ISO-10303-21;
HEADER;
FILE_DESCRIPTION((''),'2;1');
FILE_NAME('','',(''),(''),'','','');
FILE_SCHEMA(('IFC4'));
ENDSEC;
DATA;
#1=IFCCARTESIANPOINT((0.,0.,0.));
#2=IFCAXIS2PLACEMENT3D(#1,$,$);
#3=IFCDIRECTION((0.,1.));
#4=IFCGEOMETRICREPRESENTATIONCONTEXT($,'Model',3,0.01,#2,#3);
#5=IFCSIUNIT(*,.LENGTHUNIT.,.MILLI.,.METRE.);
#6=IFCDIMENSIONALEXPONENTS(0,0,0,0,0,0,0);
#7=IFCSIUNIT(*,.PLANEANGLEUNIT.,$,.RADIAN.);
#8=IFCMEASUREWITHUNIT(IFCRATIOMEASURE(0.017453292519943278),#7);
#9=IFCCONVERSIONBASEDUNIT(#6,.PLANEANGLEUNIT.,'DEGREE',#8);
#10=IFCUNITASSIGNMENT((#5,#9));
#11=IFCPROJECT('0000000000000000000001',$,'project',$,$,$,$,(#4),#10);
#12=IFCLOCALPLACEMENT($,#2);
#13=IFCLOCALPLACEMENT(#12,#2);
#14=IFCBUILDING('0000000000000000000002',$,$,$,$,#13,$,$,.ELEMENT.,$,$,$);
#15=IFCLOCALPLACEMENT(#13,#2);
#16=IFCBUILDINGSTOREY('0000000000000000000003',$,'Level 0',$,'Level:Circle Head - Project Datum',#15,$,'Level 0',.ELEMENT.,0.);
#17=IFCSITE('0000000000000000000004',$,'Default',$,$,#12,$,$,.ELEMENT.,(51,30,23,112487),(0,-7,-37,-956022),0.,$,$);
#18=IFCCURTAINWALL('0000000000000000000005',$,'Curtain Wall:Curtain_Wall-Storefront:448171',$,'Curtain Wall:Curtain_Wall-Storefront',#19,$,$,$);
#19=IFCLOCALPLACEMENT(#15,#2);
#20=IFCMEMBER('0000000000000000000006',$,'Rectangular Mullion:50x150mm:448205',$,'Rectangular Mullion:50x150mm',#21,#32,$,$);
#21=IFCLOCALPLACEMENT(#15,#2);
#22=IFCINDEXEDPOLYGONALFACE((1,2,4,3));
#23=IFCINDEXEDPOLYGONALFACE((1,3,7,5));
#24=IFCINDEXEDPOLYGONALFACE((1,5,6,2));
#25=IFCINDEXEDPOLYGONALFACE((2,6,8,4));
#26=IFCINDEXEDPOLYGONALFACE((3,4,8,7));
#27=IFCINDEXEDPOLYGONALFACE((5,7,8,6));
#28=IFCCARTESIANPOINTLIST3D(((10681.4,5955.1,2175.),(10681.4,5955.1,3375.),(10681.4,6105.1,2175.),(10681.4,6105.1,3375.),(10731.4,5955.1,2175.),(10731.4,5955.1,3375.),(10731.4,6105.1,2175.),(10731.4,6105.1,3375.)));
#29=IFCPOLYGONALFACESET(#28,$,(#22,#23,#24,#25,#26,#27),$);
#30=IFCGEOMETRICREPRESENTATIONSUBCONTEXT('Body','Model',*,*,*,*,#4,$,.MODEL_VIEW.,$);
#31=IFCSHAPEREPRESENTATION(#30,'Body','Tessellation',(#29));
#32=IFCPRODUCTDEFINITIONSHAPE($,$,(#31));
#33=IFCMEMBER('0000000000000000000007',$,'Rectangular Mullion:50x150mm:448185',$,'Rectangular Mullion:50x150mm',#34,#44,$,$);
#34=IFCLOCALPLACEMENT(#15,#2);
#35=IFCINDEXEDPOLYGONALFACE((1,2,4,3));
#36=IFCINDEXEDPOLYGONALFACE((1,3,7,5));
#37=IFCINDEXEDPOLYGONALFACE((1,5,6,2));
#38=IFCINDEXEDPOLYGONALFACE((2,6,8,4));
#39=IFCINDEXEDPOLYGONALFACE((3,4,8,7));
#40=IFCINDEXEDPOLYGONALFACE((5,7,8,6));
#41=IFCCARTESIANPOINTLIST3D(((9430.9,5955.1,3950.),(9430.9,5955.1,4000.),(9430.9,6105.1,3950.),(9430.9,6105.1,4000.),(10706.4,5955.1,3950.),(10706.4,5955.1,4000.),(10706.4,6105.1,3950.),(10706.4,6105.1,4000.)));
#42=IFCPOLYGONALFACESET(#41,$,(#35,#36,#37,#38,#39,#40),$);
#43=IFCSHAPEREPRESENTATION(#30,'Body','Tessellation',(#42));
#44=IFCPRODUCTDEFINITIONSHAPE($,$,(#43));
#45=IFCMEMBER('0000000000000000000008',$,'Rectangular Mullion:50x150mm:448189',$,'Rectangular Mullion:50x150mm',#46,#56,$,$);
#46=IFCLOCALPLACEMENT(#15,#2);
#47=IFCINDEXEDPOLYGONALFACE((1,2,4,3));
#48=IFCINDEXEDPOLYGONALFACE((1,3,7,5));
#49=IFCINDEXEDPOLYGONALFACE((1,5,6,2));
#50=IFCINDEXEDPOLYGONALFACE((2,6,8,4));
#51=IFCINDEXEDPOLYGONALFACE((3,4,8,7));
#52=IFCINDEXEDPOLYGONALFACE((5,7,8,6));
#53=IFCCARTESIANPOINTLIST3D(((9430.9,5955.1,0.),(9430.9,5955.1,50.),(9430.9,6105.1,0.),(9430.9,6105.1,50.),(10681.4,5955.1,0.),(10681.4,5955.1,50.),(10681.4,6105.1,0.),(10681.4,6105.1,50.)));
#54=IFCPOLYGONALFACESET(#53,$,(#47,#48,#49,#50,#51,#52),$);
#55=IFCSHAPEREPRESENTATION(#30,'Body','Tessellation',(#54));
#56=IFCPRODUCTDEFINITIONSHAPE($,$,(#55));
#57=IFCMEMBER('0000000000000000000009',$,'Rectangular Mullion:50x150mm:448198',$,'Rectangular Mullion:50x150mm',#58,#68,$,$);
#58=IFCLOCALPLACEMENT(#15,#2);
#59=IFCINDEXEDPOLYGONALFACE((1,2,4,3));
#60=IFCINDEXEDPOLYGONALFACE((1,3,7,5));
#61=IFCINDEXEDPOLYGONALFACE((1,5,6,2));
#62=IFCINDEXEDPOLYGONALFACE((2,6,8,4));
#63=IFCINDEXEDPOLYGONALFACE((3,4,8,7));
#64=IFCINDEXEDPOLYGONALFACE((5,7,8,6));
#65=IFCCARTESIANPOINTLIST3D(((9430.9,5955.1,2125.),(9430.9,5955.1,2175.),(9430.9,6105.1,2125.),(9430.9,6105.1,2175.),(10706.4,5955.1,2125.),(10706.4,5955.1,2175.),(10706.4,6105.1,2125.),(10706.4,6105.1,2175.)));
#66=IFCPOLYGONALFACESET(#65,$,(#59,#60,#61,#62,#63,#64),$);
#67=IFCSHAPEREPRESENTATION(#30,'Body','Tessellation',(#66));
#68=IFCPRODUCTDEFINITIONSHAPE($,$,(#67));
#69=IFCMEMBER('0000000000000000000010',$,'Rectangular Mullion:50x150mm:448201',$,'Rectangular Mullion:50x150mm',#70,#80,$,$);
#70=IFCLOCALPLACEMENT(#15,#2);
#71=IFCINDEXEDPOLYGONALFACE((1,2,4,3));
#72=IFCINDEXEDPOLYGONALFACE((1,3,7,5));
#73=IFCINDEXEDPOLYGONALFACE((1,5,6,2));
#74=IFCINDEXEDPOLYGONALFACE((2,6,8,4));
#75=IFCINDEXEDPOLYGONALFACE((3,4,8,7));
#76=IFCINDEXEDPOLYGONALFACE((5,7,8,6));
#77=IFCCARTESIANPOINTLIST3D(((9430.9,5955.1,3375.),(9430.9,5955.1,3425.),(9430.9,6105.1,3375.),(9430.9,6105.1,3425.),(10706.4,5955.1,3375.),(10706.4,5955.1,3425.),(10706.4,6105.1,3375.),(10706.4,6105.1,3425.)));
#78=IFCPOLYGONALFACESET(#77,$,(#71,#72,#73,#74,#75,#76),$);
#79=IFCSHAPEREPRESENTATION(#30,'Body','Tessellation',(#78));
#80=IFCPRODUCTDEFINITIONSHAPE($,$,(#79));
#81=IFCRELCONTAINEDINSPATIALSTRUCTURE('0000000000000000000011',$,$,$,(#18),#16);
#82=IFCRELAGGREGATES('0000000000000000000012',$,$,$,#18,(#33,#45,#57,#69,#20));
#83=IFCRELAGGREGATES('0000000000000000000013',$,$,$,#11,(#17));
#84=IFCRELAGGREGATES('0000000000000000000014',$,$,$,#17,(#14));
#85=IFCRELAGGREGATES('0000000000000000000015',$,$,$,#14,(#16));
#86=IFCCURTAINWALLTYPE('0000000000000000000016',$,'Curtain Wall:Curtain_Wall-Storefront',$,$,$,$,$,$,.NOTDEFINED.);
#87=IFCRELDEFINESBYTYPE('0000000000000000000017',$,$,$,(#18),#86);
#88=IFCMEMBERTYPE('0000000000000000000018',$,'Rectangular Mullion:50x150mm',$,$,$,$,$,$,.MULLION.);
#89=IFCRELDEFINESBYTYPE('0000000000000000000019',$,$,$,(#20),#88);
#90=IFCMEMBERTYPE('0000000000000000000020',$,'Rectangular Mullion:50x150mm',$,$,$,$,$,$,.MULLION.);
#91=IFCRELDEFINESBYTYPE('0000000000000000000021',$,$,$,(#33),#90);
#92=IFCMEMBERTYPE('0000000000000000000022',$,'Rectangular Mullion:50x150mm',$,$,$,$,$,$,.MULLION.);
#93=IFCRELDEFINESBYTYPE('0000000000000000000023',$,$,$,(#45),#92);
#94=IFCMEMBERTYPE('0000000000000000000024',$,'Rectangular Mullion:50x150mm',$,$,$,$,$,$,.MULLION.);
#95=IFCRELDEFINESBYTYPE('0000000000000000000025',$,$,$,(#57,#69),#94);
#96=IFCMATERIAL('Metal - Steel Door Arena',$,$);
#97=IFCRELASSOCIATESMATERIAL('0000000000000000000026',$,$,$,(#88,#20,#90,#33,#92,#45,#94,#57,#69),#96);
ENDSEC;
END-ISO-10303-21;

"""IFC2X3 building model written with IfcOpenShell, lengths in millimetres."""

from ifc_helpers import new_model, entity, si_unit, converted_unit, direction, frame, origin, origin_2d_with_axis, place, context, subcontext, project, spatial, rectangle, extrude, source, transform, mapped, material, type_object, type_shapes, element, aggregate, save


model = new_model("IFC2X3")

# Units and contexts
model_context = context("Model", 3, precision=0.01, world=origin(), true_north=direction((0.0, 1.0)))
body_context = subcontext(model_context, "Body", "Model", "MODEL_VIEW")
ifc_project = project(units=[si_unit("LENGTHUNIT", "METRE", prefix="MILLI"), converted_unit("PLANEANGLEUNIT", "DEGREE", entity("IfcRatioMeasure", 0.017453292519943278), si_unit("PLANEANGLEUNIT", "RADIAN"), dimensions=[0, 0, 0, 0, 0, 0, 0])], contexts=[model_context])

# Site, building, storey
site_placement = place(None, origin())
site = spatial("IfcSite", under=ifc_project, at=site_placement, Name="Default", CompositionType="ELEMENT", RefLatitude=(51, 30, 23, 112487), RefLongitude=(0, -7, -37, -956022), RefElevation=0.0)
building_placement = place(site_placement, origin())
building = spatial("IfcBuilding", under=site, at=building_placement, CompositionType="ELEMENT")
storey_placement = place(building_placement, origin())
storey = spatial("IfcBuildingStorey", under=building, at=storey_placement, Name="Level 0", ObjectType="Level:Circle Head - Project Datum", LongName="Level 0", CompositionType="ELEMENT", Elevation=0.0)

# Curtain wall
curtain_wall_type = type_object("IfcCurtainWallType", Name="Curtain Wall:Curtain_Wall-Storefront", PredefinedType="NOTDEFINED")
curtain_wall_1_placement = place(storey_placement, origin())
curtain_wall_1 = element("IfcCurtainWall", 1, at=curtain_wall_1_placement, inside=storey, type_object=curtain_wall_type, Name="Curtain Wall:Curtain_Wall-Storefront:448171", ObjectType="Curtain Wall:Curtain_Wall-Storefront")
ifc_material_1 = material(Name="Metal - Steel Door Arena")

# Members
member_type_1 = type_object("IfcMemberType", Name="Rectangular Mullion:50x150mm", PredefinedType="MULLION", material=ifc_material_1)
shared_shape_1 = source(origin(), body_context, "Body", "SweptSolid", [
    extrude(rectangle(XDim=150.0, YDim=50.0, at=origin_2d_with_axis()), frame((0.0, 0.0, -1200.0), z_axis=(0.0, 0.0, 1.0), x_axis=(0.0, -1.0, 0.0)), (0.0, 0.0, 1.0), 1200.0),
])
type_shapes(member_type_1, [shared_shape_1])
member_1_placement = place(curtain_wall_1_placement, frame((10706.4, 6030.1, 2175.0), z_axis=(0.0, 0.0, -1.0), x_axis=(-1.0, 0.0, 0.0)))
member_1 = element("IfcMember", 2, at=member_1_placement, type_object=member_type_1, material=ifc_material_1, Name="Rectangular Mullion:50x150mm:448205", ObjectType="Rectangular Mullion:50x150mm", context=body_context, shape_type="MappedRepresentation", body=[
    mapped(shared_shape_1, transform((0.0, 0.0, 0.0), scale=1.0)),
])
member_type_2 = type_object("IfcMemberType", Name="Rectangular Mullion:50x150mm", PredefinedType="MULLION", material=ifc_material_1)
shared_shape_2 = source(origin(), body_context, "Body", "SweptSolid", [
    extrude(rectangle(XDim=150.0, YDim=50.0, at=origin_2d_with_axis()), frame((-25.0, 0.0, -1275.5), z_axis=(0.0, 0.0, 1.0), x_axis=(0.0, -1.0, 0.0)), (0.0, 0.0, 1.0), 1275.5),
])
type_shapes(member_type_2, [shared_shape_2])
member_2_placement = place(curtain_wall_1_placement, frame((9430.9, 6030.1, 4000.0), z_axis=(-1.0, 0.0, 0.0), x_axis=(0.0, 0.0, 1.0)))
member_2 = element("IfcMember", 3, at=member_2_placement, type_object=member_type_2, material=ifc_material_1, Name="Rectangular Mullion:50x150mm:448185", ObjectType="Rectangular Mullion:50x150mm", context=body_context, shape_type="MappedRepresentation", body=[
    mapped(shared_shape_2, transform((0.0, 0.0, 0.0), scale=1.0)),
])
member_type_3 = type_object("IfcMemberType", Name="Rectangular Mullion:50x150mm", PredefinedType="MULLION", material=ifc_material_1)
shared_shape_3 = source(origin(), body_context, "Body", "SweptSolid", [
    extrude(rectangle(XDim=150.0, YDim=50.0, at=origin_2d_with_axis()), frame((-25.0, 0.0, -1250.5), z_axis=(0.0, 0.0, 1.0), x_axis=(0.0, -1.0, 0.0)), (0.0, 0.0, 1.0), 1250.5),
])
type_shapes(member_type_3, [shared_shape_3])
member_3_placement = place(curtain_wall_1_placement, frame((10681.4, 6030.1, 0.0), z_axis=(1.0, 0.0, 0.0), x_axis=(0.0, 0.0, -1.0)))
member_3 = element("IfcMember", 4, at=member_3_placement, type_object=member_type_3, material=ifc_material_1, Name="Rectangular Mullion:50x150mm:448189", ObjectType="Rectangular Mullion:50x150mm", context=body_context, shape_type="MappedRepresentation", body=[
    mapped(shared_shape_3, transform((0.0, 0.0, 0.0), scale=1.0)),
])
member_type_4 = type_object("IfcMemberType", Name="Rectangular Mullion:50x150mm", PredefinedType="MULLION", material=ifc_material_1)
shared_shape_4 = source(origin(), body_context, "Body", "SweptSolid", [
    extrude(rectangle(XDim=150.0, YDim=50.0, at=origin_2d_with_axis()), frame((0.0, 0.0, -1275.5), z_axis=(0.0, 0.0, 1.0), x_axis=(0.0, -1.0, 0.0)), (0.0, 0.0, 1.0), 1275.5),
])
type_shapes(member_type_4, [shared_shape_4])
member_4_placement = place(curtain_wall_1_placement, frame((9430.9, 6030.1, 2150.0), z_axis=(-1.0, 0.0, 0.0), x_axis=(0.0, 0.0, 1.0)))
member_4 = element("IfcMember", 5, at=member_4_placement, type_object=member_type_4, material=ifc_material_1, Name="Rectangular Mullion:50x150mm:448198", ObjectType="Rectangular Mullion:50x150mm", context=body_context, shape_type="MappedRepresentation", body=[
    mapped(shared_shape_4, transform((0.0, 0.0, 0.0), scale=1.0)),
])
member_5_placement = place(curtain_wall_1_placement, frame((9430.9, 6030.1, 3400.0), z_axis=(-1.0, 0.0, 0.0), x_axis=(0.0, 0.0, 1.0)))
member_5 = element("IfcMember", 6, at=member_5_placement, type_object=member_type_4, material=ifc_material_1, Name="Rectangular Mullion:50x150mm:448201", ObjectType="Rectangular Mullion:50x150mm", context=body_context, shape_type="MappedRepresentation", body=[
    mapped(shared_shape_4, transform((0.0, 0.0, 0.0), scale=1.0)),
])

aggregate(curtain_wall_1, [member_2, member_3, member_4, member_5, member_1])

save(model, "model.ifc")
